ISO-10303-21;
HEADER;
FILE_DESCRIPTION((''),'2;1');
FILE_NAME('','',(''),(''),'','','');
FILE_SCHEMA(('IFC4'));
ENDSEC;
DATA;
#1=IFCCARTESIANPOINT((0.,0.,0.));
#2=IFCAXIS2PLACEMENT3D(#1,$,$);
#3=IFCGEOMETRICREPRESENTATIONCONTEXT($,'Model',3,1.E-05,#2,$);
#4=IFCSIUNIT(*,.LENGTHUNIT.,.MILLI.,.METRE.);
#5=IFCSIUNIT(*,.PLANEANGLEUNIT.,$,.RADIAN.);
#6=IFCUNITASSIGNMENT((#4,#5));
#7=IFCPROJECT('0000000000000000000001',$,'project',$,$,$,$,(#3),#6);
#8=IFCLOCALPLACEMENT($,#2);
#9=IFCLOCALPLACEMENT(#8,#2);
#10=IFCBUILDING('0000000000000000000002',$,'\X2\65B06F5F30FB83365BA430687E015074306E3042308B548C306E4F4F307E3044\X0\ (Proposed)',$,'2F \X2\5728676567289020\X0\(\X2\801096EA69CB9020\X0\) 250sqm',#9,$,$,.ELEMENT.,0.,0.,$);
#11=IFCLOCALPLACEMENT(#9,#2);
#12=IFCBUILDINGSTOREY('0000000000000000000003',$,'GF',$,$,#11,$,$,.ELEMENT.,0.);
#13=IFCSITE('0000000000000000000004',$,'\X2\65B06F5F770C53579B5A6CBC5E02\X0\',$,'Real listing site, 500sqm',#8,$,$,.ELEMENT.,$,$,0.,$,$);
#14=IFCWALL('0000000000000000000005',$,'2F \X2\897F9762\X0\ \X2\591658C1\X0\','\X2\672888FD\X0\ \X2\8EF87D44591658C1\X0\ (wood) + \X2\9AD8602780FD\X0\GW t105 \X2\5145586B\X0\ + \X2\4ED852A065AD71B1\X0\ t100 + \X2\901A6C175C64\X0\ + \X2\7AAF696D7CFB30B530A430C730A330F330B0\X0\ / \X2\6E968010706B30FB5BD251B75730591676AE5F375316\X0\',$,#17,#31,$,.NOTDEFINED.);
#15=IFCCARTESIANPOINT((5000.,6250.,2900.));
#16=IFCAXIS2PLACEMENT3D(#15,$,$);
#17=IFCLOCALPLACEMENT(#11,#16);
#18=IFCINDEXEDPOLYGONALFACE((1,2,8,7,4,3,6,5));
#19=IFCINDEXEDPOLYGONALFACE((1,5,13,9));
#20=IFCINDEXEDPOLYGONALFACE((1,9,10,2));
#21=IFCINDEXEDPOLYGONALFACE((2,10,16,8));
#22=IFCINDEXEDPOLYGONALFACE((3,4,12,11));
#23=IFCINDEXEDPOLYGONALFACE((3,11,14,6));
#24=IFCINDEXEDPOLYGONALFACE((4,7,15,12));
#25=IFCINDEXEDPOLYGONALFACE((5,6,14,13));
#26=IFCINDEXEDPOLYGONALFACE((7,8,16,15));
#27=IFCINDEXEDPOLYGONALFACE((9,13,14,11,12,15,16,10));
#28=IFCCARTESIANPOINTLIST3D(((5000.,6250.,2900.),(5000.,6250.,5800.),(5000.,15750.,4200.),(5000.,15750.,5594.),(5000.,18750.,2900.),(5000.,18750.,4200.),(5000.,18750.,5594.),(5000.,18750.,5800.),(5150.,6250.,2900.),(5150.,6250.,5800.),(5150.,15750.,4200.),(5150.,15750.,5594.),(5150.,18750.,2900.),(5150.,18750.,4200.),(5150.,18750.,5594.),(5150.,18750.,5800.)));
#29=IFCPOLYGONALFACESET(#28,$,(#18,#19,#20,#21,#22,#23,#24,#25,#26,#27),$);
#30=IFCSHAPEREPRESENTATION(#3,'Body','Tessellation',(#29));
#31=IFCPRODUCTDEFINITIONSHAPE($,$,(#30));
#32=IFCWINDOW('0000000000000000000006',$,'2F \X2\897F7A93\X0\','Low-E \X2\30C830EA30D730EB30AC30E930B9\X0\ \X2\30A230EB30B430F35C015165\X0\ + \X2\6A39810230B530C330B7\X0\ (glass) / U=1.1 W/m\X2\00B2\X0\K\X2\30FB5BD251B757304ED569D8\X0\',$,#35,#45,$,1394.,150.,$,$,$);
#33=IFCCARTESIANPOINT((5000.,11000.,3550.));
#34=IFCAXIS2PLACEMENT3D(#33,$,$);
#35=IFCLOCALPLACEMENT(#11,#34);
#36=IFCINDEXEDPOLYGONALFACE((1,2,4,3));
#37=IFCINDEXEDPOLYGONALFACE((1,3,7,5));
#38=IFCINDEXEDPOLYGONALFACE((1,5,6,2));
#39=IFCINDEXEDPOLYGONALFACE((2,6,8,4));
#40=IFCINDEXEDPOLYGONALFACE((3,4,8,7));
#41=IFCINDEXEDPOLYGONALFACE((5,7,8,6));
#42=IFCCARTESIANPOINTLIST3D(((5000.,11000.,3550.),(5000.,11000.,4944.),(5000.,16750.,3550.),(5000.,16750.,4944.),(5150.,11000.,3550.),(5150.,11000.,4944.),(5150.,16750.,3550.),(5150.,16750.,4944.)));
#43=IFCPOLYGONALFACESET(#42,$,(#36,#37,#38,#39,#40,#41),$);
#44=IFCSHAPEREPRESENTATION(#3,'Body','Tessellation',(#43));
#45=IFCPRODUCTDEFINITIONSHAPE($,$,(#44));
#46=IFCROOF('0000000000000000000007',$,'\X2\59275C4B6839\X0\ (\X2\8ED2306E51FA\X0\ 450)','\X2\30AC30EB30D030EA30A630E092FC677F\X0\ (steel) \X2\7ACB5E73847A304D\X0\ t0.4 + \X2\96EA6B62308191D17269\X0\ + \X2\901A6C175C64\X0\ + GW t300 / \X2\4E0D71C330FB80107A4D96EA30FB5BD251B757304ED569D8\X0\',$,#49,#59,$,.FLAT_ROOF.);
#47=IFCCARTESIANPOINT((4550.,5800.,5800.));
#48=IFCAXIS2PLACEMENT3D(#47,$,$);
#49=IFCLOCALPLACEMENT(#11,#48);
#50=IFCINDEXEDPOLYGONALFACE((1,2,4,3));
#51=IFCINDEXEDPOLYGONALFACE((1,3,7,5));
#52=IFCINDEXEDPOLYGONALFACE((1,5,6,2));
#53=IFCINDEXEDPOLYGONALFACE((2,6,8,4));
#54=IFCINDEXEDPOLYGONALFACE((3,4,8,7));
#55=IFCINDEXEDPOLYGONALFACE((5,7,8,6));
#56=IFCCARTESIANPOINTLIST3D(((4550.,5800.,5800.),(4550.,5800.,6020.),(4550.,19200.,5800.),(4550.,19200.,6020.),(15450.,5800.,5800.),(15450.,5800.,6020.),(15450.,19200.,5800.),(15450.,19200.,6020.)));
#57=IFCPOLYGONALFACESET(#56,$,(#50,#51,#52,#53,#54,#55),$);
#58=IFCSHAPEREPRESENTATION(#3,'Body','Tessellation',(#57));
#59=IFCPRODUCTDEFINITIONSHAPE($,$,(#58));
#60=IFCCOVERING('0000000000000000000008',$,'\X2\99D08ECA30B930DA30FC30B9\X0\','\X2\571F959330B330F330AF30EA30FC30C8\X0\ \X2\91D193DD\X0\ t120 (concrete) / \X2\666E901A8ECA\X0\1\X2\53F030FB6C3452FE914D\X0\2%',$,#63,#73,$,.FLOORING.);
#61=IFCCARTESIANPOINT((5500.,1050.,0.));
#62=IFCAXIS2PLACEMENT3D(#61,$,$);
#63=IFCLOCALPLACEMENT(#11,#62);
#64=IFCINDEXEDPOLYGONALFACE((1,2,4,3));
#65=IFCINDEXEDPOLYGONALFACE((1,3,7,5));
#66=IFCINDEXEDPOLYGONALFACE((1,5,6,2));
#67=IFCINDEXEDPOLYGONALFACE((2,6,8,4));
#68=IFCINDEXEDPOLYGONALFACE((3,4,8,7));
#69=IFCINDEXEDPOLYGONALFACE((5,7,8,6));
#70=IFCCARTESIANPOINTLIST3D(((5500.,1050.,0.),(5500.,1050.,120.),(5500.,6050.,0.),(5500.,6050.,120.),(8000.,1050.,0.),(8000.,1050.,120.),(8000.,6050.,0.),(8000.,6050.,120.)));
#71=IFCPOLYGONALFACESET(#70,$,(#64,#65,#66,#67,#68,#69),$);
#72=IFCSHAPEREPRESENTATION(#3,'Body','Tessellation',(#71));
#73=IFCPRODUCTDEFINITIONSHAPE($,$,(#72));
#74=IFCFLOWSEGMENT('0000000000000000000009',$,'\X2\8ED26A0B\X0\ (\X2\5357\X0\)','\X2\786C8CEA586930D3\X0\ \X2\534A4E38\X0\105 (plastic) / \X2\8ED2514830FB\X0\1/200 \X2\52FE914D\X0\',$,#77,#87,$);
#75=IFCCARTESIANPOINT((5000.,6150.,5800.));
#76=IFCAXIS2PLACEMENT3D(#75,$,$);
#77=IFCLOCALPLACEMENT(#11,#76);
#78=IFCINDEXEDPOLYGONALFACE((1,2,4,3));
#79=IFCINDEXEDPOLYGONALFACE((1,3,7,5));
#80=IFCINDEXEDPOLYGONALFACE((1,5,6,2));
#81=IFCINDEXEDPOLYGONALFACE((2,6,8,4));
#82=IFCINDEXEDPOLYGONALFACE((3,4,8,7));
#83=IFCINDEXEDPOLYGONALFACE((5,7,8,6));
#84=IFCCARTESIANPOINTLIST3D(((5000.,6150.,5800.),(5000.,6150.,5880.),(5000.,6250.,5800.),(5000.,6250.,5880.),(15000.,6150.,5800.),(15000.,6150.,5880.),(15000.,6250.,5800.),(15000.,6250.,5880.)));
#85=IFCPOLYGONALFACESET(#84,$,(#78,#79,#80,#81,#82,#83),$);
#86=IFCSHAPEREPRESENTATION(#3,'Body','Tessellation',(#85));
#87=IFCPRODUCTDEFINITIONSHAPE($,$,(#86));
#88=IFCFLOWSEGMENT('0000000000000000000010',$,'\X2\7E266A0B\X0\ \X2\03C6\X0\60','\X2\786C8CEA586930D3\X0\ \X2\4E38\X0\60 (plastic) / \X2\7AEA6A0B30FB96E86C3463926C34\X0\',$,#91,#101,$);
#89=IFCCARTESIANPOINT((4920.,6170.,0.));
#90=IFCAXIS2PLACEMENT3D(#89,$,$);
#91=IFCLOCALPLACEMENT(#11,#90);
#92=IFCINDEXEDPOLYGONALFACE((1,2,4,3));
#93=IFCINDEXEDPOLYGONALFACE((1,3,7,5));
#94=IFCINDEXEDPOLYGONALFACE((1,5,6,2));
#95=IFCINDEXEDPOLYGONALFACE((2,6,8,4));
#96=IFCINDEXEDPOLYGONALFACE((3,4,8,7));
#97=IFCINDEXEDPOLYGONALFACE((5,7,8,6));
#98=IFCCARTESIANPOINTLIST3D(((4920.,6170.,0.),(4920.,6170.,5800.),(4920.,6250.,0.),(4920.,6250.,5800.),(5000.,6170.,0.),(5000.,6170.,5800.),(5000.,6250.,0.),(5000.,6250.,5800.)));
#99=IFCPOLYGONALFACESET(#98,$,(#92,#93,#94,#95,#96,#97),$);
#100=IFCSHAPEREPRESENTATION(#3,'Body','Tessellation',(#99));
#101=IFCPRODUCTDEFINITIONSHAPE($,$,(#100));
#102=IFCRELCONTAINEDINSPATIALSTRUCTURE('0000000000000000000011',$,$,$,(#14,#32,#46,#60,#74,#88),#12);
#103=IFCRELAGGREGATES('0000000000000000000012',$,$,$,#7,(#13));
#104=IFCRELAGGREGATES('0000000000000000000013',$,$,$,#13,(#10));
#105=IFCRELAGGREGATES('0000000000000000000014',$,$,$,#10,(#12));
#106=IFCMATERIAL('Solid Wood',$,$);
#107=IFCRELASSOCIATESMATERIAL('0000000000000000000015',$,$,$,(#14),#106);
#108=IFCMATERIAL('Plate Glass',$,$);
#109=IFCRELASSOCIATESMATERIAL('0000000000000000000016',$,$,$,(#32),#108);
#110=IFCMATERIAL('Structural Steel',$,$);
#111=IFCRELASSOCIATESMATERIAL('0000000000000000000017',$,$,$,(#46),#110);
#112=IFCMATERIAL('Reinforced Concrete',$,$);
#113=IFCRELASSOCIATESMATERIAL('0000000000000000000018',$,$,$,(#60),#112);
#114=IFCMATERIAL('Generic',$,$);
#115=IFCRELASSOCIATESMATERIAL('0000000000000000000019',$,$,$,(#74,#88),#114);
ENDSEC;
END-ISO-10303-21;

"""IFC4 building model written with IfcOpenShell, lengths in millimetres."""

from ifc_helpers import new_model, si_unit, frame, frame_2d, origin, place, context, project, spatial, rectangle, extrude, material, element, fill, save


model = new_model("IFC4")

# Units and contexts
model_context = context("Model", 3, precision=1e-05, world=origin())
ifc_project = project(units=[si_unit("LENGTHUNIT", "METRE", prefix="MILLI"), si_unit("PLANEANGLEUNIT", "RADIAN")], contexts=[model_context])

# Site, building, storey
site_placement = place(None, origin())
site = spatial("IfcSite", under=ifc_project, at=site_placement, Name="新潟県南魚沼市", ObjectType="Real listing site, 500sqm", CompositionType="ELEMENT", RefElevation=0.0)
building_placement = place(site_placement, origin())
building = spatial("IfcBuilding", under=site, at=building_placement, Name="新潟・茶室と縁側のある和の住まい (Proposed)", ObjectType="2F 在来木造(耐雪構造) 250sqm", CompositionType="ELEMENT", ElevationOfRefHeight=0.0, ElevationOfTerrain=0.0)
storey_placement = place(building_placement, origin())
storey = spatial("IfcBuildingStorey", under=building, at=storey_placement, Name="GF", CompositionType="ELEMENT", Elevation=0.0)

# Shared definitions
ifc_material_1 = material(Name="Solid Wood")

# Shared definitions
ifc_material_2 = material(Name="Reinforced Concrete")

# Shared definitions
ifc_material_3 = material(Name="Plate Glass")

# Wall, opening, window
wall_1_placement = place(storey_placement, frame((5000.0, 6250.0, 2900.0)))
wall_1 = element("IfcWall", 1, at=wall_1_placement, inside=storey, material=ifc_material_1, Name="2F 西面 外壁", Description="木製 軸組外壁 (wood) + 高性能GW t105 充填 + 付加断熱 t100 + 通気層 + 窯業系サイディング / 準耐火・寒冷地外皮強化", PredefinedType="NOTDEFINED", context=model_context, shape_type="SweptSolid", body=[
    extrude(rectangle(XDim=150.0, YDim=12500.0, at=frame_2d((75.0, 6250.0))), frame((5000.0, 6250.0, 2900.0)), (0.0, 0.0, 1.0), 2900.0),
])
opening_1_placement = place(storey_placement, frame((5000.0, 11000.0, 3550.0)))
opening_1 = element("IfcOpeningElement", 2, at=opening_1_placement, cuts=wall_1, PredefinedType="NOTDEFINED", context=model_context, shape_type="SweptSolid", body=[
    extrude(rectangle(XDim=150.0, YDim=5750.0, at=frame_2d((75.0, 2875.0))), frame((5000.0, 11000.0, 3550.0)), (0.0, 0.0, 1.0), 1394.0),
])
window_1_placement = place(storey_placement, frame((5000.0, 11000.0, 3550.0)))
window_1 = element("IfcWindow", 3, at=window_1_placement, inside=storey, material=ifc_material_3, Name="2F 西窓", Description="Low-E トリプルガラス アルゴン封入 + 樹脂サッシ (glass) / U=1.1 W/m²K・寒冷地仕様", OverallHeight=1394.0, OverallWidth=150.0, context=model_context, shape_type="SweptSolid", body=[
    extrude(rectangle(XDim=150.0, YDim=5750.0, at=frame_2d((75.0, 2875.0))), frame((5000.0, 11000.0, 3550.0)), (0.0, 0.0, 1.0), 1394.0),
])
fill(opening_1, window_1)

# Roof
ifc_material_4 = material(Name="Structural Steel")
roof_placement = place(storey_placement, frame((4550.0, 5800.0, 5800.0)))
element("IfcRoof", 4, at=roof_placement, inside=storey, material=ifc_material_4, Name="大屋根 (軒の出 450)", Description="ガルバリウム鋼板 (steel) 立平葺き t0.4 + 雪止め金物 + 通気層 + GW t300 / 不燃・耐積雪・寒冷地仕様", PredefinedType="FLAT_ROOF", context=model_context, shape_type="SweptSolid", body=[
    extrude(rectangle(XDim=10900.0, YDim=13400.0, at=frame_2d((5450.0, 6700.0))), frame((4550.0, 5800.0, 5800.0)), (0.0, 0.0, 1.0), 220.0),
])

# Covering
covering_placement = place(storey_placement, frame((5500.0, 1050.0, 0.0)))
element("IfcCovering", 5, at=covering_placement, inside=storey, material=ifc_material_2, Name="駐車スペース", Description="土間コンクリート 金鏝 t120 (concrete) / 普通車1台・水勾配2%", PredefinedType="FLOORING", context=model_context, shape_type="SweptSolid", body=[
    extrude(rectangle(XDim=2500.0, YDim=5000.0, at=frame_2d((1250.0, 2500.0))), frame((5500.0, 1050.0, 0.0)), (0.0, 0.0, 1.0), 120.0),
])

# Flow segments
ifc_material_5 = material(Name="Generic")
flow_segment_1_placement = place(storey_placement, frame((5000.0, 6150.0, 5800.0)))
element("IfcFlowSegment", 6, at=flow_segment_1_placement, inside=storey, material=ifc_material_5, Name="軒樋 (南)", Description="硬質塩ビ 半丸105 (plastic) / 軒先・1/200 勾配", context=model_context, shape_type="SweptSolid", body=[
    extrude(rectangle(XDim=10000.0, YDim=100.0, at=frame_2d((5000.0, 50.0))), frame((5000.0, 6150.0, 5800.0)), (0.0, 0.0, 1.0), 80.0),
])
flow_segment_2_placement = place(storey_placement, frame((4920.0, 6170.0, 0.0)))
element("IfcFlowSegment", 7, at=flow_segment_2_placement, inside=storey, material=ifc_material_5, Name="縦樋 φ60", Description="硬質塩ビ 丸60 (plastic) / 竪樋・雨水排水", context=model_context, shape_type="SweptSolid", body=[
    extrude(rectangle(XDim=80.0, YDim=80.0, at=frame_2d((40.0, 40.0))), frame((4920.0, 6170.0, 0.0)), (0.0, 0.0, 1.0), 5800.0),
])

save(model, "model.ifc")
